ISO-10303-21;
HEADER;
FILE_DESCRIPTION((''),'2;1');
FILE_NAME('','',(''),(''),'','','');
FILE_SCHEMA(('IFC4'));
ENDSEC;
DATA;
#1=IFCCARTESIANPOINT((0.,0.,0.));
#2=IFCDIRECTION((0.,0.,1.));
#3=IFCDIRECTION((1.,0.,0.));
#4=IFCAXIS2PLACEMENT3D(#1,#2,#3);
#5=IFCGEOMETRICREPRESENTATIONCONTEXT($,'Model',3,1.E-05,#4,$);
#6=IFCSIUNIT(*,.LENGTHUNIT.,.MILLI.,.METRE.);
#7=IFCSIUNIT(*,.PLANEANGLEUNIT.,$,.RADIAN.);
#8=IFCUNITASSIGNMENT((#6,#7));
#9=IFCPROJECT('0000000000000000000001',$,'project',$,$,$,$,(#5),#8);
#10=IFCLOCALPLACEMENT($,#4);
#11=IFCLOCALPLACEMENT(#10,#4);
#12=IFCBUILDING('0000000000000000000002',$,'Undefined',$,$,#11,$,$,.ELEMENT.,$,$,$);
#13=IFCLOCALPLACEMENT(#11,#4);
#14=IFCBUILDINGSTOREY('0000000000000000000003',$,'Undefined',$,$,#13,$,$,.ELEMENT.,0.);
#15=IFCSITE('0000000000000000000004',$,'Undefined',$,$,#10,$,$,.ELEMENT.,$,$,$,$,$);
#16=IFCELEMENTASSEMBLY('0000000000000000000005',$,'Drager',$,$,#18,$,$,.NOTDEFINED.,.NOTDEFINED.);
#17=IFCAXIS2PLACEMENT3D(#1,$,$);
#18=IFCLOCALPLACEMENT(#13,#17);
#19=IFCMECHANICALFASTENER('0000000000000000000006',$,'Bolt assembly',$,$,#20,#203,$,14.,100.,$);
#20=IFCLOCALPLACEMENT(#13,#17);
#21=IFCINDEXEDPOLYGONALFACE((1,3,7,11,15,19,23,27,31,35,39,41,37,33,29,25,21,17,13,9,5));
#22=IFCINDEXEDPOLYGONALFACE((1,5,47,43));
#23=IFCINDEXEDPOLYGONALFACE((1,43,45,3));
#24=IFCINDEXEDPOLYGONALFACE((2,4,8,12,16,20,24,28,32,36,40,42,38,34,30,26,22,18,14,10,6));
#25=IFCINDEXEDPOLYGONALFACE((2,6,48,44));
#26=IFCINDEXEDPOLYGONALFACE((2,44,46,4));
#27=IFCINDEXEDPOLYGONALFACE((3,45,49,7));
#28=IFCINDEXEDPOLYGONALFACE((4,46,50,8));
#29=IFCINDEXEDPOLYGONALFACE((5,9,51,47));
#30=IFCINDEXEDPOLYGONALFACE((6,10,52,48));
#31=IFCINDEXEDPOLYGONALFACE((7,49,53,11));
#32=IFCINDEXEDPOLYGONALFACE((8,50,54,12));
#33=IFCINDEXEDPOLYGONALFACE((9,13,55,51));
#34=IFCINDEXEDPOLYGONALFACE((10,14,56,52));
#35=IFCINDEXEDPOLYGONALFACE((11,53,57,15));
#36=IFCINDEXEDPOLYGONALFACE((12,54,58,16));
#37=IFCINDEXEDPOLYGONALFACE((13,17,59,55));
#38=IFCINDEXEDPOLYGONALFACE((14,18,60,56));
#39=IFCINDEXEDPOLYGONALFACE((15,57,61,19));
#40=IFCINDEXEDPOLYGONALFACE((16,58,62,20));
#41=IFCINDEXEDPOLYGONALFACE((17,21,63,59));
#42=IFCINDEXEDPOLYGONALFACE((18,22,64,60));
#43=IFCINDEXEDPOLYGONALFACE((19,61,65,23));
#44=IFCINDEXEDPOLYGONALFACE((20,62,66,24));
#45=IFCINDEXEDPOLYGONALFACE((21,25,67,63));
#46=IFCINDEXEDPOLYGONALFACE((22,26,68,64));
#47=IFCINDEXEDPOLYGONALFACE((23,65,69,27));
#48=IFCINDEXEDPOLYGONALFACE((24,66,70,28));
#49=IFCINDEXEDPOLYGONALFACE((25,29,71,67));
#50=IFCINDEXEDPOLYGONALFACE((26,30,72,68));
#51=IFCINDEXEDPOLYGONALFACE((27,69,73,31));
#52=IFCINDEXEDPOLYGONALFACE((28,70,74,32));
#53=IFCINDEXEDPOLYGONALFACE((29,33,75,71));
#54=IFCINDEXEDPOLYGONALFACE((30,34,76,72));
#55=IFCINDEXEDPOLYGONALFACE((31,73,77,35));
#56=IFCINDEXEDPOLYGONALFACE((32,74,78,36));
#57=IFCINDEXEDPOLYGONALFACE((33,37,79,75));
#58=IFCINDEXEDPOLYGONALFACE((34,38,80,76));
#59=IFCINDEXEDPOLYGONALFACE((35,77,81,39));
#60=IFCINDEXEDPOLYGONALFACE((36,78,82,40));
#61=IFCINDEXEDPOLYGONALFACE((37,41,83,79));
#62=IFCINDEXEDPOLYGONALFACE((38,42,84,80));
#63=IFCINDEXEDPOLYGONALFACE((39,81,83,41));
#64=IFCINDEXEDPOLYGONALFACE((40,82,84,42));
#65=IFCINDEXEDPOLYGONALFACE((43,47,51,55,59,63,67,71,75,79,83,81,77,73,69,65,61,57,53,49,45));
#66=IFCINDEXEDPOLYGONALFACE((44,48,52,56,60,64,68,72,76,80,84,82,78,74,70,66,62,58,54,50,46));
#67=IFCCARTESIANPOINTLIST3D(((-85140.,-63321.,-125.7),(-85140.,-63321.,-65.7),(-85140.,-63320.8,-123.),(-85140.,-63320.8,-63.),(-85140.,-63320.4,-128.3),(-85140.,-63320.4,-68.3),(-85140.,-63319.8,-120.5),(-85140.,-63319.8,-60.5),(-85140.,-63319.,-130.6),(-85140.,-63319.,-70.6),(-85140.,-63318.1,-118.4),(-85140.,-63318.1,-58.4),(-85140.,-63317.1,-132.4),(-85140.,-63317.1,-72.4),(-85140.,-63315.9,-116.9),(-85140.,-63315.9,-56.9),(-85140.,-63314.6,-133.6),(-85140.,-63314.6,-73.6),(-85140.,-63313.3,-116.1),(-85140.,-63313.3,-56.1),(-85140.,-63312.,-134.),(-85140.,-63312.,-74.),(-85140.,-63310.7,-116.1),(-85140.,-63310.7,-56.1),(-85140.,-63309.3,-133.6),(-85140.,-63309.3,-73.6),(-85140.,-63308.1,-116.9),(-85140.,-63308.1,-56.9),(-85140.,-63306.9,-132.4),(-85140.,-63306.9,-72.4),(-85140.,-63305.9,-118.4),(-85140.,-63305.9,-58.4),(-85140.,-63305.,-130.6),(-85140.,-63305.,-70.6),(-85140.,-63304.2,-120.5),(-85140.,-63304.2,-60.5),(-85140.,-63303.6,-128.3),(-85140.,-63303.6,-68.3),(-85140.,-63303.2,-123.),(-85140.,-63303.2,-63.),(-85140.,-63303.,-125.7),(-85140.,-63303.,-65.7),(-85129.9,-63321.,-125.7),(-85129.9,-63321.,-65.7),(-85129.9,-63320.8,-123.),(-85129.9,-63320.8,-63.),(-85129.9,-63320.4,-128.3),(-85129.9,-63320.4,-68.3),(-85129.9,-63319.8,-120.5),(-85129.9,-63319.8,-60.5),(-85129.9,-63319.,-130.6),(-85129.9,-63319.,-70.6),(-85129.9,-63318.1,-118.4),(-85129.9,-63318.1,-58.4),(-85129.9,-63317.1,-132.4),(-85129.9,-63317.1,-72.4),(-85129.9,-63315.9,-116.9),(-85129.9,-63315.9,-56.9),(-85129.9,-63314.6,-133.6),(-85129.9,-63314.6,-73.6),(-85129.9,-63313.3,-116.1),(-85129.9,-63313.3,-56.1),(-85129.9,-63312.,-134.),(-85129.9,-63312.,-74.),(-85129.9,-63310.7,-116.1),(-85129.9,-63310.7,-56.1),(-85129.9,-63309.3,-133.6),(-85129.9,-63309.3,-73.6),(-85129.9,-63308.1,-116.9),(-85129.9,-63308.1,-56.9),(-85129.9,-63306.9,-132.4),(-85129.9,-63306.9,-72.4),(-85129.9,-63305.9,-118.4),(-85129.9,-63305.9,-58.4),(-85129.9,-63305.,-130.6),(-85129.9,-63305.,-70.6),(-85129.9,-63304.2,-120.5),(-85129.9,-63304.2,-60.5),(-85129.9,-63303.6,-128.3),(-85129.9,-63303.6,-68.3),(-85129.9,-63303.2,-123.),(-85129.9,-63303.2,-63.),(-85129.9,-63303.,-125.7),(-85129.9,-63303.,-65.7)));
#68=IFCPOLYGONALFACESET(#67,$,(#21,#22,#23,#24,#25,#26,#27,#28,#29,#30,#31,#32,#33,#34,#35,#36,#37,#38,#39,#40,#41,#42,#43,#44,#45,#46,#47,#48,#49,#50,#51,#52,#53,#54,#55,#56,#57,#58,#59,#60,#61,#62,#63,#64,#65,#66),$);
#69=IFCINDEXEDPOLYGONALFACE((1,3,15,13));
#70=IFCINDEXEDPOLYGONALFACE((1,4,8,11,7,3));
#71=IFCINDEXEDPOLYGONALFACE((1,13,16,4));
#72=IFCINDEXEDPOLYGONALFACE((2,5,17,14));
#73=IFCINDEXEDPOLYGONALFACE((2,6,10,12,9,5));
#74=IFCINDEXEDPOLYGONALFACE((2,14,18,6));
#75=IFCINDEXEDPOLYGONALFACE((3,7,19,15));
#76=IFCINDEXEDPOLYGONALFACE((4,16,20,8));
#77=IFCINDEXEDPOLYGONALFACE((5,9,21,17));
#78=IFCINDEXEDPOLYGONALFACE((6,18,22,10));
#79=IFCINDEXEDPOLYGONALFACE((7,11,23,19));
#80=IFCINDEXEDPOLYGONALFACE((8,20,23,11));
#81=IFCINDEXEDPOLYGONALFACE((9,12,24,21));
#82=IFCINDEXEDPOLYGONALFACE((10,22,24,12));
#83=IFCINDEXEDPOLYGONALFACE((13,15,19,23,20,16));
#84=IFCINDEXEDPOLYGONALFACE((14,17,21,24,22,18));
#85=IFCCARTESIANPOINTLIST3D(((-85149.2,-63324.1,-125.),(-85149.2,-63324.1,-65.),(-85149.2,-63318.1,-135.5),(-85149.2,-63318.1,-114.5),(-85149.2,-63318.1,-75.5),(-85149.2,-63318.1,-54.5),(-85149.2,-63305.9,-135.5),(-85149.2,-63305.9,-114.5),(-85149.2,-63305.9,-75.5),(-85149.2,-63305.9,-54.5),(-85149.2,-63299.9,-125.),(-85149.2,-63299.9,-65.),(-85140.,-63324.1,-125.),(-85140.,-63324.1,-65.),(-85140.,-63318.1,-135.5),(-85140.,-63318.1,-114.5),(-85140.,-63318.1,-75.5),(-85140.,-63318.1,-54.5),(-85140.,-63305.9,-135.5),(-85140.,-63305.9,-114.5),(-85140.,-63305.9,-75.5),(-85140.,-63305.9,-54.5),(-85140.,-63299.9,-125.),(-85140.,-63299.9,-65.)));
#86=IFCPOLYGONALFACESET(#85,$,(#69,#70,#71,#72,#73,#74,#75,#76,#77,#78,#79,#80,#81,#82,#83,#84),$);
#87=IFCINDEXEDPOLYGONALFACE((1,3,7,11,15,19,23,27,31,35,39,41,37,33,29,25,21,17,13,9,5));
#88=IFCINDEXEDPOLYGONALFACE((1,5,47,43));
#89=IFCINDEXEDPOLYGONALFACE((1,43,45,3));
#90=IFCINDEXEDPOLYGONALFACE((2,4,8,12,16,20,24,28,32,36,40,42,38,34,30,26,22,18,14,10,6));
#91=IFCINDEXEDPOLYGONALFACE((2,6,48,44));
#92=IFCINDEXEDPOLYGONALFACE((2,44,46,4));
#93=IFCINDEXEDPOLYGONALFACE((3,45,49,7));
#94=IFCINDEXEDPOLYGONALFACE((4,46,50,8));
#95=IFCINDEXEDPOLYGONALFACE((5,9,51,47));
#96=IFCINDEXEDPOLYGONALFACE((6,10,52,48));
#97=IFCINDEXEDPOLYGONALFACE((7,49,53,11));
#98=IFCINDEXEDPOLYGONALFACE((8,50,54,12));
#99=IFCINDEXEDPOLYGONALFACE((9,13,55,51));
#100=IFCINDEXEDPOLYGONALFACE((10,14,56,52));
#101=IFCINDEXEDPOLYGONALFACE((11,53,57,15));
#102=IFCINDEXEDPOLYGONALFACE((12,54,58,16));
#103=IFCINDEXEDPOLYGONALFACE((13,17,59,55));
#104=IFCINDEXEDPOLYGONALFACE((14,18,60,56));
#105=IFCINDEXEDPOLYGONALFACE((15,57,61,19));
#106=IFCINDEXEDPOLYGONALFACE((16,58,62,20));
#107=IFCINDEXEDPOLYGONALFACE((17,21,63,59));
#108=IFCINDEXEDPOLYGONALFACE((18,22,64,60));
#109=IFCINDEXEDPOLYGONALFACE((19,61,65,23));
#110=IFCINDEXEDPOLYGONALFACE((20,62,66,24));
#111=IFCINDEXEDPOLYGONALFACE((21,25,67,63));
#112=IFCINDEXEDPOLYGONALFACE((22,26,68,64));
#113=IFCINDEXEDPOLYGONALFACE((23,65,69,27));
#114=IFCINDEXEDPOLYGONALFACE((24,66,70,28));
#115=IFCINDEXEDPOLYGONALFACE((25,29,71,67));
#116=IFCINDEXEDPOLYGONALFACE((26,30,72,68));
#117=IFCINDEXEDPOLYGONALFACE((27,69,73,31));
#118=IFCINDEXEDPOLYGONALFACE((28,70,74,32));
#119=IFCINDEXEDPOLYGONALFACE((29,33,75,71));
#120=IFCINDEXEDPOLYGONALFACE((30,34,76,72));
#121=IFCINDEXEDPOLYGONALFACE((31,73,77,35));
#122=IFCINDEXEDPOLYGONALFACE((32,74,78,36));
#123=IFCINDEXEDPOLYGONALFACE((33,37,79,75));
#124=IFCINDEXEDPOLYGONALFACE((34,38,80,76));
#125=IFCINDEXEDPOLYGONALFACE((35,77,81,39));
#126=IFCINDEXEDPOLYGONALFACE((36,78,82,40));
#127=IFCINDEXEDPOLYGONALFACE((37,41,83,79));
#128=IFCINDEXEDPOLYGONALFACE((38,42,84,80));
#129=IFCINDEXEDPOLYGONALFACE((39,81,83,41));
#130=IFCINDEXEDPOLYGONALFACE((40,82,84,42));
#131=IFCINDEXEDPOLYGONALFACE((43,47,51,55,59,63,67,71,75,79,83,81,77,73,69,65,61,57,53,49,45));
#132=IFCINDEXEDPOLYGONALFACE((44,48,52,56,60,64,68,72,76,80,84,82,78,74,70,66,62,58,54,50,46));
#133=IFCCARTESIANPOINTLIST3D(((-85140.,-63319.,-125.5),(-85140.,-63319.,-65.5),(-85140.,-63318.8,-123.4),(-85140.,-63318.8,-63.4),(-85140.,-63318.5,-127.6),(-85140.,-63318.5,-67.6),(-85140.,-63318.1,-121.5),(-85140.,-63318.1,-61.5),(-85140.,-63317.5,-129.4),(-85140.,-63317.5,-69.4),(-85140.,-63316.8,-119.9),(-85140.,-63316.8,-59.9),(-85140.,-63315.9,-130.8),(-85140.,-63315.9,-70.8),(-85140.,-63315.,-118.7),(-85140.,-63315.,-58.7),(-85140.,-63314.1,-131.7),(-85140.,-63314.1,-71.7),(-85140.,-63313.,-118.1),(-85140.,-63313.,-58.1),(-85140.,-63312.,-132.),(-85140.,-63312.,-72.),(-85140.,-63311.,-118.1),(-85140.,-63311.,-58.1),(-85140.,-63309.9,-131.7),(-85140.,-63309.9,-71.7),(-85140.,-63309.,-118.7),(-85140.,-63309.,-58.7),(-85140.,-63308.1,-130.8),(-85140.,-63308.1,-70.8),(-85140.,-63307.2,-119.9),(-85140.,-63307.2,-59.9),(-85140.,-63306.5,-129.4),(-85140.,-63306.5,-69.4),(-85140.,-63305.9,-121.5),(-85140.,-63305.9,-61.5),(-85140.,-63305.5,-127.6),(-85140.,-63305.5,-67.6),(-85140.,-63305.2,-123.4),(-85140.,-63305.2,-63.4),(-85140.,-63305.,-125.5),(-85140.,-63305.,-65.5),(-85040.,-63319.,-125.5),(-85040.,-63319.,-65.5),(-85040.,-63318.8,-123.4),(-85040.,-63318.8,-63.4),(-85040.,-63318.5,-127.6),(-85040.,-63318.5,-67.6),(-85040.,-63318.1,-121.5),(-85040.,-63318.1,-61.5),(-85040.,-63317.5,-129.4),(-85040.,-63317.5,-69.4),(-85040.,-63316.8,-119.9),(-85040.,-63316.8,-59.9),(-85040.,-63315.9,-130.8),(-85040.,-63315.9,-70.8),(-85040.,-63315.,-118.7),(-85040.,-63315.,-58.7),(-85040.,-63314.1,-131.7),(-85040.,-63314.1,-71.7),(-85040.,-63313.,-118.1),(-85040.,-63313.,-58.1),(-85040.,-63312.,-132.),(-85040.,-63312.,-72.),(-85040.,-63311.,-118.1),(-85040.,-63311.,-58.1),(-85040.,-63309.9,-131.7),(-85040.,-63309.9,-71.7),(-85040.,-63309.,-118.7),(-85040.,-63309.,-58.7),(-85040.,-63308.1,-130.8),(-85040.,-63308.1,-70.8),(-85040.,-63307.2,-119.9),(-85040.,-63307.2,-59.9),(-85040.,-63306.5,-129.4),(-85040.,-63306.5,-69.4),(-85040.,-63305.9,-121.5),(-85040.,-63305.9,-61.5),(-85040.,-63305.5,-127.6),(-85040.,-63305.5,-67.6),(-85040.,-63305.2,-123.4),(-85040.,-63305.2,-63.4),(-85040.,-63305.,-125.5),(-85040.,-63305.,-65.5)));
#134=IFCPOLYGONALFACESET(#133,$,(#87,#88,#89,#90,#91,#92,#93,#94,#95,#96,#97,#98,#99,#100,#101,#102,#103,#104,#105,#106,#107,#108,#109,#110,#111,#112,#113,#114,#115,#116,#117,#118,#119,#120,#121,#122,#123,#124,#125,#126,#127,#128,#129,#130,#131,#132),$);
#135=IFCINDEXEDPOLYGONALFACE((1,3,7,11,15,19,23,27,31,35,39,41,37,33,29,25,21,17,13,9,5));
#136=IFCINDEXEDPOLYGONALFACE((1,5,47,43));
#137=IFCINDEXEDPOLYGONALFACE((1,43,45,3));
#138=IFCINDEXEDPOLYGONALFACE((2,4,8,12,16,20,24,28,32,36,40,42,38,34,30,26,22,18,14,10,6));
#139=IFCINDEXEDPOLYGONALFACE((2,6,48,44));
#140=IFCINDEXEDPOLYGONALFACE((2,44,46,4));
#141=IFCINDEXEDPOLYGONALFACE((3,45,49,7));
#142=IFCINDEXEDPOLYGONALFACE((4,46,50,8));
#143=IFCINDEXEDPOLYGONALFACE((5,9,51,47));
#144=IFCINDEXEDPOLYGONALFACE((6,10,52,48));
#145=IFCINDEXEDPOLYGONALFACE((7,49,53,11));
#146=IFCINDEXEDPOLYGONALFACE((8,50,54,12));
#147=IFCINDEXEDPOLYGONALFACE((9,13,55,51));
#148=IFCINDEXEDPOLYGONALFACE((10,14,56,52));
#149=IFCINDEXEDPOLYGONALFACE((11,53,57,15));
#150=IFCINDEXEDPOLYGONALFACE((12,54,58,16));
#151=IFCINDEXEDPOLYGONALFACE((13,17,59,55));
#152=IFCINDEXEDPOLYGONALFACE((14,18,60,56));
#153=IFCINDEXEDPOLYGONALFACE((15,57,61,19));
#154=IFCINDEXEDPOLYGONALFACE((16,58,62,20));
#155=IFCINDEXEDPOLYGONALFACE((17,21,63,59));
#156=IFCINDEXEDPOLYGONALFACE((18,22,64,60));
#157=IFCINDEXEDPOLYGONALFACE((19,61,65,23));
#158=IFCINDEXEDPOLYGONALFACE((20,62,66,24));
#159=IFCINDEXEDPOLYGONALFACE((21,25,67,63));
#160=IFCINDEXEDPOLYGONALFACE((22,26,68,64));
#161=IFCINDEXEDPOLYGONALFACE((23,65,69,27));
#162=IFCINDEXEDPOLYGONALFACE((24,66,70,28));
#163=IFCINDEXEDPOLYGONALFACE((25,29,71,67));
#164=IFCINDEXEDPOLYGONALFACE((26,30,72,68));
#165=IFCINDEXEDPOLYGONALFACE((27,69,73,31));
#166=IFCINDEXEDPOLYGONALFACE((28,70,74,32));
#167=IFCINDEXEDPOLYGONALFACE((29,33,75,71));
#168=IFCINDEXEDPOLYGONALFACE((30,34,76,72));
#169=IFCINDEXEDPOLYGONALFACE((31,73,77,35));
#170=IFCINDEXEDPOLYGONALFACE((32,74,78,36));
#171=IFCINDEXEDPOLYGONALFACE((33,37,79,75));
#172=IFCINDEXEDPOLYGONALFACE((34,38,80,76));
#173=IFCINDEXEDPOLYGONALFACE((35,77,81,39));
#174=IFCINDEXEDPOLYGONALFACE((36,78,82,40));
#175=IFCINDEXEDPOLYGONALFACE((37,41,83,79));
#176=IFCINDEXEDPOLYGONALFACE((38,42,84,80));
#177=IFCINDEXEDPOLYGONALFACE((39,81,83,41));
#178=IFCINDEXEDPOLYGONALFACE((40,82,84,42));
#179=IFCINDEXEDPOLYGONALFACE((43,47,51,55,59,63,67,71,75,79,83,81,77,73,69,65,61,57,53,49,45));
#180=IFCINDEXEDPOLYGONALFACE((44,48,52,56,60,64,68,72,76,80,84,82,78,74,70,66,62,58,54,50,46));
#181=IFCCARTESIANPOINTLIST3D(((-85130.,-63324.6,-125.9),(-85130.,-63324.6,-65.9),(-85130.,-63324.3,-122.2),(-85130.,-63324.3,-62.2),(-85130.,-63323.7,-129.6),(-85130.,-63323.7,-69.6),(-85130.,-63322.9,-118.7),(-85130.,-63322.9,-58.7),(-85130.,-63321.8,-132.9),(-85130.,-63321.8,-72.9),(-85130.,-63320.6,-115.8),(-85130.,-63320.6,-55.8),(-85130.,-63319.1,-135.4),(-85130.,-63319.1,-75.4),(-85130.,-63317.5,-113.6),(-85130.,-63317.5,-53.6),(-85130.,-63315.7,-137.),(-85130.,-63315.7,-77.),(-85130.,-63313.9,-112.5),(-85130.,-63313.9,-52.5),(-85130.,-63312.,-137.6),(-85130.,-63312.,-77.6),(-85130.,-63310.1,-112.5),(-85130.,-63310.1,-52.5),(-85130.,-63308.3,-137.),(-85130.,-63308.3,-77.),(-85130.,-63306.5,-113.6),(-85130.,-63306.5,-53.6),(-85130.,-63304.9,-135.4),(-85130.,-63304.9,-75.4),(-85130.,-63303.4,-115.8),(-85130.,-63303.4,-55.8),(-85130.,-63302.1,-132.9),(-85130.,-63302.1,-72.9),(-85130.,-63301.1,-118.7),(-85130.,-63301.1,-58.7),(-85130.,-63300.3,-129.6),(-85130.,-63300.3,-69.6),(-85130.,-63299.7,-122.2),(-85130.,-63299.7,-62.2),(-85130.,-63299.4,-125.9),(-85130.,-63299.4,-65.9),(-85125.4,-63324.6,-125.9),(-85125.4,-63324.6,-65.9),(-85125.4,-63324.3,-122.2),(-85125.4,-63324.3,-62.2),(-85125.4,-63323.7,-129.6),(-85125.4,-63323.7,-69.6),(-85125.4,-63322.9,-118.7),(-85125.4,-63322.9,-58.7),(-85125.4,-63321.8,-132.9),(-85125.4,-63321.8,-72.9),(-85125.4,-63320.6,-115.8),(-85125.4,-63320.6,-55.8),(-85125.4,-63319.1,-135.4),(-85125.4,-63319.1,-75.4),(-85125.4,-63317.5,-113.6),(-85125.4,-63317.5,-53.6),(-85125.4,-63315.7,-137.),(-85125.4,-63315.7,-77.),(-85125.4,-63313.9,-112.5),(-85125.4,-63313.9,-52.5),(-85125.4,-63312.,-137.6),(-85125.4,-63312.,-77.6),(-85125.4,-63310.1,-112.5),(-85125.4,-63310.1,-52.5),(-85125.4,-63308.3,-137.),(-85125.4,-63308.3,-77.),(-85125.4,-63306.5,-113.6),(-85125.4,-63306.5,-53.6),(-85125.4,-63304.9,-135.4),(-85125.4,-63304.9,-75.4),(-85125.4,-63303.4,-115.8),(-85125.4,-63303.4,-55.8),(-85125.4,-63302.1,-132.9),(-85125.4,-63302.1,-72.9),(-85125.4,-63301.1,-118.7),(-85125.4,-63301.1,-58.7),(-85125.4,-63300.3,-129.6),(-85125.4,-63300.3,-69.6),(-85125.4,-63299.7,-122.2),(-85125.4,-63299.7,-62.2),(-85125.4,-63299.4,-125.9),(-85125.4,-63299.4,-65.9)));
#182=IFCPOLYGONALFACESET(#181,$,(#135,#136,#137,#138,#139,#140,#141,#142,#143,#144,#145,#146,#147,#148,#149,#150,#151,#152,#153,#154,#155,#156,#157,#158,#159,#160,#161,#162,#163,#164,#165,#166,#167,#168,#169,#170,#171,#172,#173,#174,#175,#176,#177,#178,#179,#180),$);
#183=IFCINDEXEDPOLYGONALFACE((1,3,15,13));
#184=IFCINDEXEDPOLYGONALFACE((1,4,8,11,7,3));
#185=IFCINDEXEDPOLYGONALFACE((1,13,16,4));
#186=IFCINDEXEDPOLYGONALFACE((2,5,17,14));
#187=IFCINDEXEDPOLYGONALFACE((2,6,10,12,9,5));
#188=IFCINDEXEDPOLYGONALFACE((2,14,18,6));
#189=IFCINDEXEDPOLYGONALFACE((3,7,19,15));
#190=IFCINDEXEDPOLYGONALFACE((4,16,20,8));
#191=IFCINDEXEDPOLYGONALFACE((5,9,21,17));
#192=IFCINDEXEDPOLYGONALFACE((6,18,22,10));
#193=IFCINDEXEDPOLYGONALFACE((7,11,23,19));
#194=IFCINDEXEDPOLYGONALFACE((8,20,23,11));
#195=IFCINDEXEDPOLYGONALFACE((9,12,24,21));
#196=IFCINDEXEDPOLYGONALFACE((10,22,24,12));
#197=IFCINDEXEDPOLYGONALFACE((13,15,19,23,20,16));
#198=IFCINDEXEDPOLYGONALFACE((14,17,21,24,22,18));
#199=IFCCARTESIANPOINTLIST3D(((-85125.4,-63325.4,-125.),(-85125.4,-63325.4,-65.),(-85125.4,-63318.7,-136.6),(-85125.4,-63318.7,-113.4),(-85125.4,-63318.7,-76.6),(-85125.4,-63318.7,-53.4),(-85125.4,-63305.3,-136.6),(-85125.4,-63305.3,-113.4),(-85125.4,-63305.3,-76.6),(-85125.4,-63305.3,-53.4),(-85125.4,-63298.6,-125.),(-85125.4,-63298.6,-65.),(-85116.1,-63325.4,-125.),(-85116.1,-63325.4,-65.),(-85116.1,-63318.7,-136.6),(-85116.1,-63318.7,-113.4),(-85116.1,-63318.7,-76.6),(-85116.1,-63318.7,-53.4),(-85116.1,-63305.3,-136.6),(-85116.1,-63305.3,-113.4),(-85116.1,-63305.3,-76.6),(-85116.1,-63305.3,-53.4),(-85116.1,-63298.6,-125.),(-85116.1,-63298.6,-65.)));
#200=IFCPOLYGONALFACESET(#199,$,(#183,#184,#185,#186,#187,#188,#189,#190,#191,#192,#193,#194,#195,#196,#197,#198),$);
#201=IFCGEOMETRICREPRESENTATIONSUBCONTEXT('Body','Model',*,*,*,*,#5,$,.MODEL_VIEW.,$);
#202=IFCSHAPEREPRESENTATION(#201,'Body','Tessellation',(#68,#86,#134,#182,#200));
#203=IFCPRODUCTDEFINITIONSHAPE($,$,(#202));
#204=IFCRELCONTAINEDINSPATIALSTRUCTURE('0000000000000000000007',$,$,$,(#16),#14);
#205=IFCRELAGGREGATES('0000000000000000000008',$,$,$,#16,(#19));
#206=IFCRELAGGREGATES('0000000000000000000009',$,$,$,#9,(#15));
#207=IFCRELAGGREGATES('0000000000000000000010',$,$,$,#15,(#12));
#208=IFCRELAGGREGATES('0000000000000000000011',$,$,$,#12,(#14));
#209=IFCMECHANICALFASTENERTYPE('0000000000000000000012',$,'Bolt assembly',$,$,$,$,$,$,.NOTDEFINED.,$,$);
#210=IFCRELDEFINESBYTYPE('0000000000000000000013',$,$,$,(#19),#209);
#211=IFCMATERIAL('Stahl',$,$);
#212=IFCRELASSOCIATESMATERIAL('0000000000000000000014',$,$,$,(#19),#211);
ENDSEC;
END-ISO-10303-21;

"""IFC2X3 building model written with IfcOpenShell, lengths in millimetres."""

from ifc_helpers import new_model, si_unit, frame, origin_with_axes, origin_2d_with_axis, place, context, subcontext, project, spatial, polyline, circle, outline, extrude, source, transform, mapped, material, type_object, element, aggregate, save


model = new_model("IFC2X3")

# Units and contexts
model_context = context("Model", 3, precision=1e-05, world=origin_with_axes())
body_context = subcontext(model_context, "Body", "Model", "MODEL_VIEW")
ifc_project = project(units=[si_unit("LENGTHUNIT", "METRE", prefix="MILLI"), si_unit("PLANEANGLEUNIT", "RADIAN")], contexts=[model_context])

# Site, building, storey
site_placement = place(None, origin_with_axes())
site = spatial("IfcSite", under=ifc_project, at=site_placement, Name="Undefined", CompositionType="ELEMENT")
building_placement = place(site_placement, origin_with_axes())
building = spatial("IfcBuilding", under=site, at=building_placement, Name="Undefined", CompositionType="ELEMENT")
storey_placement = place(building_placement, origin_with_axes())
storey = spatial("IfcBuildingStorey", under=building, at=storey_placement, Name="Undefined", CompositionType="ELEMENT", Elevation=0.0)

# Element assembly
assembly_1_placement = place(storey_placement, origin_with_axes())
assembly_1 = element("IfcElementAssembly", 1, at=assembly_1_placement, inside=storey, Name="Drager", AssemblyPlace="NOTDEFINED", PredefinedType="NOTDEFINED")

# Shared definitions
mechanical_fastener_type = type_object("IfcMechanicalFastenerType", Name="Bolt assembly")

# Mechanical fastener
ifc_material_1 = material(Name="Stahl")
shared_shape_1 = source(origin_with_axes(), body_context, "Body", "SweptSolid", [
    extrude(circle(Radius=9.0, at=origin_2d_with_axis()), frame((0.0, 0.0, 0.0), z_axis=(0.0, 1.0, 0.0), x_axis=(1.0, 0.0, 0.0)), (0.0, 0.0, 1.0), 10.1),
    extrude(outline(polyline([(10.5, -6.1), (10.5, 6.1), (0.0, 12.1), (-10.5, 6.1), (-10.5, -6.1), (0.0, -12.1), (10.5, -6.1)])), frame((0.0, -9.2, 0.0), z_axis=(0.0, 1.0, 0.0), x_axis=(1.0, 0.0, 0.0)), (0.0, 0.0, 1.0), 9.2),
    extrude(circle(Radius=7.0, at=origin_2d_with_axis()), frame((0.0, 0.0, 0.0), z_axis=(0.0, 1.0, 0.0), x_axis=(1.0, 0.0, 0.0)), (0.0, 0.0, 1.0), 100.0),
    extrude(circle(Radius=12.6, at=origin_2d_with_axis()), frame((0.0, 10.0, 0.0), z_axis=(0.0, 1.0, 0.0), x_axis=(1.0, 0.0, 0.0)), (0.0, 0.0, 1.0), 4.6),
    extrude(outline(polyline([(11.6, -6.7), (11.6, 6.7), (0.0, 13.4), (-11.6, 6.7), (-11.6, -6.7), (0.0, -13.4), (11.6, -6.7)])), frame((0.0, 14.6, 0.0), z_axis=(0.0, 1.0, 0.0), x_axis=(1.0, 0.0, 0.0)), (0.0, 0.0, 1.0), 9.2),
])
mechanical_fastener_1_placement = place(assembly_1_placement, frame((-85140.0, -63312.0, -65.0), z_axis=(0.0, -1.0, 0.0), x_axis=(0.0, 0.0, -1.0)))
mechanical_fastener_1 = element("IfcMechanicalFastener", 2, at=mechanical_fastener_1_placement, type_object=mechanical_fastener_type, material=ifc_material_1, Name="Bolt assembly", NominalDiameter=14.0, NominalLength=100.0, context=body_context, shape_type="MappedRepresentation", body=[
    mapped(shared_shape_1, transform((0.0, 0.0, 0.0))),
    mapped(shared_shape_1, transform((60.0, 0.0, 0.0))),
])
aggregate(assembly_1, [mechanical_fastener_1])

save(model, "model.ifc")
